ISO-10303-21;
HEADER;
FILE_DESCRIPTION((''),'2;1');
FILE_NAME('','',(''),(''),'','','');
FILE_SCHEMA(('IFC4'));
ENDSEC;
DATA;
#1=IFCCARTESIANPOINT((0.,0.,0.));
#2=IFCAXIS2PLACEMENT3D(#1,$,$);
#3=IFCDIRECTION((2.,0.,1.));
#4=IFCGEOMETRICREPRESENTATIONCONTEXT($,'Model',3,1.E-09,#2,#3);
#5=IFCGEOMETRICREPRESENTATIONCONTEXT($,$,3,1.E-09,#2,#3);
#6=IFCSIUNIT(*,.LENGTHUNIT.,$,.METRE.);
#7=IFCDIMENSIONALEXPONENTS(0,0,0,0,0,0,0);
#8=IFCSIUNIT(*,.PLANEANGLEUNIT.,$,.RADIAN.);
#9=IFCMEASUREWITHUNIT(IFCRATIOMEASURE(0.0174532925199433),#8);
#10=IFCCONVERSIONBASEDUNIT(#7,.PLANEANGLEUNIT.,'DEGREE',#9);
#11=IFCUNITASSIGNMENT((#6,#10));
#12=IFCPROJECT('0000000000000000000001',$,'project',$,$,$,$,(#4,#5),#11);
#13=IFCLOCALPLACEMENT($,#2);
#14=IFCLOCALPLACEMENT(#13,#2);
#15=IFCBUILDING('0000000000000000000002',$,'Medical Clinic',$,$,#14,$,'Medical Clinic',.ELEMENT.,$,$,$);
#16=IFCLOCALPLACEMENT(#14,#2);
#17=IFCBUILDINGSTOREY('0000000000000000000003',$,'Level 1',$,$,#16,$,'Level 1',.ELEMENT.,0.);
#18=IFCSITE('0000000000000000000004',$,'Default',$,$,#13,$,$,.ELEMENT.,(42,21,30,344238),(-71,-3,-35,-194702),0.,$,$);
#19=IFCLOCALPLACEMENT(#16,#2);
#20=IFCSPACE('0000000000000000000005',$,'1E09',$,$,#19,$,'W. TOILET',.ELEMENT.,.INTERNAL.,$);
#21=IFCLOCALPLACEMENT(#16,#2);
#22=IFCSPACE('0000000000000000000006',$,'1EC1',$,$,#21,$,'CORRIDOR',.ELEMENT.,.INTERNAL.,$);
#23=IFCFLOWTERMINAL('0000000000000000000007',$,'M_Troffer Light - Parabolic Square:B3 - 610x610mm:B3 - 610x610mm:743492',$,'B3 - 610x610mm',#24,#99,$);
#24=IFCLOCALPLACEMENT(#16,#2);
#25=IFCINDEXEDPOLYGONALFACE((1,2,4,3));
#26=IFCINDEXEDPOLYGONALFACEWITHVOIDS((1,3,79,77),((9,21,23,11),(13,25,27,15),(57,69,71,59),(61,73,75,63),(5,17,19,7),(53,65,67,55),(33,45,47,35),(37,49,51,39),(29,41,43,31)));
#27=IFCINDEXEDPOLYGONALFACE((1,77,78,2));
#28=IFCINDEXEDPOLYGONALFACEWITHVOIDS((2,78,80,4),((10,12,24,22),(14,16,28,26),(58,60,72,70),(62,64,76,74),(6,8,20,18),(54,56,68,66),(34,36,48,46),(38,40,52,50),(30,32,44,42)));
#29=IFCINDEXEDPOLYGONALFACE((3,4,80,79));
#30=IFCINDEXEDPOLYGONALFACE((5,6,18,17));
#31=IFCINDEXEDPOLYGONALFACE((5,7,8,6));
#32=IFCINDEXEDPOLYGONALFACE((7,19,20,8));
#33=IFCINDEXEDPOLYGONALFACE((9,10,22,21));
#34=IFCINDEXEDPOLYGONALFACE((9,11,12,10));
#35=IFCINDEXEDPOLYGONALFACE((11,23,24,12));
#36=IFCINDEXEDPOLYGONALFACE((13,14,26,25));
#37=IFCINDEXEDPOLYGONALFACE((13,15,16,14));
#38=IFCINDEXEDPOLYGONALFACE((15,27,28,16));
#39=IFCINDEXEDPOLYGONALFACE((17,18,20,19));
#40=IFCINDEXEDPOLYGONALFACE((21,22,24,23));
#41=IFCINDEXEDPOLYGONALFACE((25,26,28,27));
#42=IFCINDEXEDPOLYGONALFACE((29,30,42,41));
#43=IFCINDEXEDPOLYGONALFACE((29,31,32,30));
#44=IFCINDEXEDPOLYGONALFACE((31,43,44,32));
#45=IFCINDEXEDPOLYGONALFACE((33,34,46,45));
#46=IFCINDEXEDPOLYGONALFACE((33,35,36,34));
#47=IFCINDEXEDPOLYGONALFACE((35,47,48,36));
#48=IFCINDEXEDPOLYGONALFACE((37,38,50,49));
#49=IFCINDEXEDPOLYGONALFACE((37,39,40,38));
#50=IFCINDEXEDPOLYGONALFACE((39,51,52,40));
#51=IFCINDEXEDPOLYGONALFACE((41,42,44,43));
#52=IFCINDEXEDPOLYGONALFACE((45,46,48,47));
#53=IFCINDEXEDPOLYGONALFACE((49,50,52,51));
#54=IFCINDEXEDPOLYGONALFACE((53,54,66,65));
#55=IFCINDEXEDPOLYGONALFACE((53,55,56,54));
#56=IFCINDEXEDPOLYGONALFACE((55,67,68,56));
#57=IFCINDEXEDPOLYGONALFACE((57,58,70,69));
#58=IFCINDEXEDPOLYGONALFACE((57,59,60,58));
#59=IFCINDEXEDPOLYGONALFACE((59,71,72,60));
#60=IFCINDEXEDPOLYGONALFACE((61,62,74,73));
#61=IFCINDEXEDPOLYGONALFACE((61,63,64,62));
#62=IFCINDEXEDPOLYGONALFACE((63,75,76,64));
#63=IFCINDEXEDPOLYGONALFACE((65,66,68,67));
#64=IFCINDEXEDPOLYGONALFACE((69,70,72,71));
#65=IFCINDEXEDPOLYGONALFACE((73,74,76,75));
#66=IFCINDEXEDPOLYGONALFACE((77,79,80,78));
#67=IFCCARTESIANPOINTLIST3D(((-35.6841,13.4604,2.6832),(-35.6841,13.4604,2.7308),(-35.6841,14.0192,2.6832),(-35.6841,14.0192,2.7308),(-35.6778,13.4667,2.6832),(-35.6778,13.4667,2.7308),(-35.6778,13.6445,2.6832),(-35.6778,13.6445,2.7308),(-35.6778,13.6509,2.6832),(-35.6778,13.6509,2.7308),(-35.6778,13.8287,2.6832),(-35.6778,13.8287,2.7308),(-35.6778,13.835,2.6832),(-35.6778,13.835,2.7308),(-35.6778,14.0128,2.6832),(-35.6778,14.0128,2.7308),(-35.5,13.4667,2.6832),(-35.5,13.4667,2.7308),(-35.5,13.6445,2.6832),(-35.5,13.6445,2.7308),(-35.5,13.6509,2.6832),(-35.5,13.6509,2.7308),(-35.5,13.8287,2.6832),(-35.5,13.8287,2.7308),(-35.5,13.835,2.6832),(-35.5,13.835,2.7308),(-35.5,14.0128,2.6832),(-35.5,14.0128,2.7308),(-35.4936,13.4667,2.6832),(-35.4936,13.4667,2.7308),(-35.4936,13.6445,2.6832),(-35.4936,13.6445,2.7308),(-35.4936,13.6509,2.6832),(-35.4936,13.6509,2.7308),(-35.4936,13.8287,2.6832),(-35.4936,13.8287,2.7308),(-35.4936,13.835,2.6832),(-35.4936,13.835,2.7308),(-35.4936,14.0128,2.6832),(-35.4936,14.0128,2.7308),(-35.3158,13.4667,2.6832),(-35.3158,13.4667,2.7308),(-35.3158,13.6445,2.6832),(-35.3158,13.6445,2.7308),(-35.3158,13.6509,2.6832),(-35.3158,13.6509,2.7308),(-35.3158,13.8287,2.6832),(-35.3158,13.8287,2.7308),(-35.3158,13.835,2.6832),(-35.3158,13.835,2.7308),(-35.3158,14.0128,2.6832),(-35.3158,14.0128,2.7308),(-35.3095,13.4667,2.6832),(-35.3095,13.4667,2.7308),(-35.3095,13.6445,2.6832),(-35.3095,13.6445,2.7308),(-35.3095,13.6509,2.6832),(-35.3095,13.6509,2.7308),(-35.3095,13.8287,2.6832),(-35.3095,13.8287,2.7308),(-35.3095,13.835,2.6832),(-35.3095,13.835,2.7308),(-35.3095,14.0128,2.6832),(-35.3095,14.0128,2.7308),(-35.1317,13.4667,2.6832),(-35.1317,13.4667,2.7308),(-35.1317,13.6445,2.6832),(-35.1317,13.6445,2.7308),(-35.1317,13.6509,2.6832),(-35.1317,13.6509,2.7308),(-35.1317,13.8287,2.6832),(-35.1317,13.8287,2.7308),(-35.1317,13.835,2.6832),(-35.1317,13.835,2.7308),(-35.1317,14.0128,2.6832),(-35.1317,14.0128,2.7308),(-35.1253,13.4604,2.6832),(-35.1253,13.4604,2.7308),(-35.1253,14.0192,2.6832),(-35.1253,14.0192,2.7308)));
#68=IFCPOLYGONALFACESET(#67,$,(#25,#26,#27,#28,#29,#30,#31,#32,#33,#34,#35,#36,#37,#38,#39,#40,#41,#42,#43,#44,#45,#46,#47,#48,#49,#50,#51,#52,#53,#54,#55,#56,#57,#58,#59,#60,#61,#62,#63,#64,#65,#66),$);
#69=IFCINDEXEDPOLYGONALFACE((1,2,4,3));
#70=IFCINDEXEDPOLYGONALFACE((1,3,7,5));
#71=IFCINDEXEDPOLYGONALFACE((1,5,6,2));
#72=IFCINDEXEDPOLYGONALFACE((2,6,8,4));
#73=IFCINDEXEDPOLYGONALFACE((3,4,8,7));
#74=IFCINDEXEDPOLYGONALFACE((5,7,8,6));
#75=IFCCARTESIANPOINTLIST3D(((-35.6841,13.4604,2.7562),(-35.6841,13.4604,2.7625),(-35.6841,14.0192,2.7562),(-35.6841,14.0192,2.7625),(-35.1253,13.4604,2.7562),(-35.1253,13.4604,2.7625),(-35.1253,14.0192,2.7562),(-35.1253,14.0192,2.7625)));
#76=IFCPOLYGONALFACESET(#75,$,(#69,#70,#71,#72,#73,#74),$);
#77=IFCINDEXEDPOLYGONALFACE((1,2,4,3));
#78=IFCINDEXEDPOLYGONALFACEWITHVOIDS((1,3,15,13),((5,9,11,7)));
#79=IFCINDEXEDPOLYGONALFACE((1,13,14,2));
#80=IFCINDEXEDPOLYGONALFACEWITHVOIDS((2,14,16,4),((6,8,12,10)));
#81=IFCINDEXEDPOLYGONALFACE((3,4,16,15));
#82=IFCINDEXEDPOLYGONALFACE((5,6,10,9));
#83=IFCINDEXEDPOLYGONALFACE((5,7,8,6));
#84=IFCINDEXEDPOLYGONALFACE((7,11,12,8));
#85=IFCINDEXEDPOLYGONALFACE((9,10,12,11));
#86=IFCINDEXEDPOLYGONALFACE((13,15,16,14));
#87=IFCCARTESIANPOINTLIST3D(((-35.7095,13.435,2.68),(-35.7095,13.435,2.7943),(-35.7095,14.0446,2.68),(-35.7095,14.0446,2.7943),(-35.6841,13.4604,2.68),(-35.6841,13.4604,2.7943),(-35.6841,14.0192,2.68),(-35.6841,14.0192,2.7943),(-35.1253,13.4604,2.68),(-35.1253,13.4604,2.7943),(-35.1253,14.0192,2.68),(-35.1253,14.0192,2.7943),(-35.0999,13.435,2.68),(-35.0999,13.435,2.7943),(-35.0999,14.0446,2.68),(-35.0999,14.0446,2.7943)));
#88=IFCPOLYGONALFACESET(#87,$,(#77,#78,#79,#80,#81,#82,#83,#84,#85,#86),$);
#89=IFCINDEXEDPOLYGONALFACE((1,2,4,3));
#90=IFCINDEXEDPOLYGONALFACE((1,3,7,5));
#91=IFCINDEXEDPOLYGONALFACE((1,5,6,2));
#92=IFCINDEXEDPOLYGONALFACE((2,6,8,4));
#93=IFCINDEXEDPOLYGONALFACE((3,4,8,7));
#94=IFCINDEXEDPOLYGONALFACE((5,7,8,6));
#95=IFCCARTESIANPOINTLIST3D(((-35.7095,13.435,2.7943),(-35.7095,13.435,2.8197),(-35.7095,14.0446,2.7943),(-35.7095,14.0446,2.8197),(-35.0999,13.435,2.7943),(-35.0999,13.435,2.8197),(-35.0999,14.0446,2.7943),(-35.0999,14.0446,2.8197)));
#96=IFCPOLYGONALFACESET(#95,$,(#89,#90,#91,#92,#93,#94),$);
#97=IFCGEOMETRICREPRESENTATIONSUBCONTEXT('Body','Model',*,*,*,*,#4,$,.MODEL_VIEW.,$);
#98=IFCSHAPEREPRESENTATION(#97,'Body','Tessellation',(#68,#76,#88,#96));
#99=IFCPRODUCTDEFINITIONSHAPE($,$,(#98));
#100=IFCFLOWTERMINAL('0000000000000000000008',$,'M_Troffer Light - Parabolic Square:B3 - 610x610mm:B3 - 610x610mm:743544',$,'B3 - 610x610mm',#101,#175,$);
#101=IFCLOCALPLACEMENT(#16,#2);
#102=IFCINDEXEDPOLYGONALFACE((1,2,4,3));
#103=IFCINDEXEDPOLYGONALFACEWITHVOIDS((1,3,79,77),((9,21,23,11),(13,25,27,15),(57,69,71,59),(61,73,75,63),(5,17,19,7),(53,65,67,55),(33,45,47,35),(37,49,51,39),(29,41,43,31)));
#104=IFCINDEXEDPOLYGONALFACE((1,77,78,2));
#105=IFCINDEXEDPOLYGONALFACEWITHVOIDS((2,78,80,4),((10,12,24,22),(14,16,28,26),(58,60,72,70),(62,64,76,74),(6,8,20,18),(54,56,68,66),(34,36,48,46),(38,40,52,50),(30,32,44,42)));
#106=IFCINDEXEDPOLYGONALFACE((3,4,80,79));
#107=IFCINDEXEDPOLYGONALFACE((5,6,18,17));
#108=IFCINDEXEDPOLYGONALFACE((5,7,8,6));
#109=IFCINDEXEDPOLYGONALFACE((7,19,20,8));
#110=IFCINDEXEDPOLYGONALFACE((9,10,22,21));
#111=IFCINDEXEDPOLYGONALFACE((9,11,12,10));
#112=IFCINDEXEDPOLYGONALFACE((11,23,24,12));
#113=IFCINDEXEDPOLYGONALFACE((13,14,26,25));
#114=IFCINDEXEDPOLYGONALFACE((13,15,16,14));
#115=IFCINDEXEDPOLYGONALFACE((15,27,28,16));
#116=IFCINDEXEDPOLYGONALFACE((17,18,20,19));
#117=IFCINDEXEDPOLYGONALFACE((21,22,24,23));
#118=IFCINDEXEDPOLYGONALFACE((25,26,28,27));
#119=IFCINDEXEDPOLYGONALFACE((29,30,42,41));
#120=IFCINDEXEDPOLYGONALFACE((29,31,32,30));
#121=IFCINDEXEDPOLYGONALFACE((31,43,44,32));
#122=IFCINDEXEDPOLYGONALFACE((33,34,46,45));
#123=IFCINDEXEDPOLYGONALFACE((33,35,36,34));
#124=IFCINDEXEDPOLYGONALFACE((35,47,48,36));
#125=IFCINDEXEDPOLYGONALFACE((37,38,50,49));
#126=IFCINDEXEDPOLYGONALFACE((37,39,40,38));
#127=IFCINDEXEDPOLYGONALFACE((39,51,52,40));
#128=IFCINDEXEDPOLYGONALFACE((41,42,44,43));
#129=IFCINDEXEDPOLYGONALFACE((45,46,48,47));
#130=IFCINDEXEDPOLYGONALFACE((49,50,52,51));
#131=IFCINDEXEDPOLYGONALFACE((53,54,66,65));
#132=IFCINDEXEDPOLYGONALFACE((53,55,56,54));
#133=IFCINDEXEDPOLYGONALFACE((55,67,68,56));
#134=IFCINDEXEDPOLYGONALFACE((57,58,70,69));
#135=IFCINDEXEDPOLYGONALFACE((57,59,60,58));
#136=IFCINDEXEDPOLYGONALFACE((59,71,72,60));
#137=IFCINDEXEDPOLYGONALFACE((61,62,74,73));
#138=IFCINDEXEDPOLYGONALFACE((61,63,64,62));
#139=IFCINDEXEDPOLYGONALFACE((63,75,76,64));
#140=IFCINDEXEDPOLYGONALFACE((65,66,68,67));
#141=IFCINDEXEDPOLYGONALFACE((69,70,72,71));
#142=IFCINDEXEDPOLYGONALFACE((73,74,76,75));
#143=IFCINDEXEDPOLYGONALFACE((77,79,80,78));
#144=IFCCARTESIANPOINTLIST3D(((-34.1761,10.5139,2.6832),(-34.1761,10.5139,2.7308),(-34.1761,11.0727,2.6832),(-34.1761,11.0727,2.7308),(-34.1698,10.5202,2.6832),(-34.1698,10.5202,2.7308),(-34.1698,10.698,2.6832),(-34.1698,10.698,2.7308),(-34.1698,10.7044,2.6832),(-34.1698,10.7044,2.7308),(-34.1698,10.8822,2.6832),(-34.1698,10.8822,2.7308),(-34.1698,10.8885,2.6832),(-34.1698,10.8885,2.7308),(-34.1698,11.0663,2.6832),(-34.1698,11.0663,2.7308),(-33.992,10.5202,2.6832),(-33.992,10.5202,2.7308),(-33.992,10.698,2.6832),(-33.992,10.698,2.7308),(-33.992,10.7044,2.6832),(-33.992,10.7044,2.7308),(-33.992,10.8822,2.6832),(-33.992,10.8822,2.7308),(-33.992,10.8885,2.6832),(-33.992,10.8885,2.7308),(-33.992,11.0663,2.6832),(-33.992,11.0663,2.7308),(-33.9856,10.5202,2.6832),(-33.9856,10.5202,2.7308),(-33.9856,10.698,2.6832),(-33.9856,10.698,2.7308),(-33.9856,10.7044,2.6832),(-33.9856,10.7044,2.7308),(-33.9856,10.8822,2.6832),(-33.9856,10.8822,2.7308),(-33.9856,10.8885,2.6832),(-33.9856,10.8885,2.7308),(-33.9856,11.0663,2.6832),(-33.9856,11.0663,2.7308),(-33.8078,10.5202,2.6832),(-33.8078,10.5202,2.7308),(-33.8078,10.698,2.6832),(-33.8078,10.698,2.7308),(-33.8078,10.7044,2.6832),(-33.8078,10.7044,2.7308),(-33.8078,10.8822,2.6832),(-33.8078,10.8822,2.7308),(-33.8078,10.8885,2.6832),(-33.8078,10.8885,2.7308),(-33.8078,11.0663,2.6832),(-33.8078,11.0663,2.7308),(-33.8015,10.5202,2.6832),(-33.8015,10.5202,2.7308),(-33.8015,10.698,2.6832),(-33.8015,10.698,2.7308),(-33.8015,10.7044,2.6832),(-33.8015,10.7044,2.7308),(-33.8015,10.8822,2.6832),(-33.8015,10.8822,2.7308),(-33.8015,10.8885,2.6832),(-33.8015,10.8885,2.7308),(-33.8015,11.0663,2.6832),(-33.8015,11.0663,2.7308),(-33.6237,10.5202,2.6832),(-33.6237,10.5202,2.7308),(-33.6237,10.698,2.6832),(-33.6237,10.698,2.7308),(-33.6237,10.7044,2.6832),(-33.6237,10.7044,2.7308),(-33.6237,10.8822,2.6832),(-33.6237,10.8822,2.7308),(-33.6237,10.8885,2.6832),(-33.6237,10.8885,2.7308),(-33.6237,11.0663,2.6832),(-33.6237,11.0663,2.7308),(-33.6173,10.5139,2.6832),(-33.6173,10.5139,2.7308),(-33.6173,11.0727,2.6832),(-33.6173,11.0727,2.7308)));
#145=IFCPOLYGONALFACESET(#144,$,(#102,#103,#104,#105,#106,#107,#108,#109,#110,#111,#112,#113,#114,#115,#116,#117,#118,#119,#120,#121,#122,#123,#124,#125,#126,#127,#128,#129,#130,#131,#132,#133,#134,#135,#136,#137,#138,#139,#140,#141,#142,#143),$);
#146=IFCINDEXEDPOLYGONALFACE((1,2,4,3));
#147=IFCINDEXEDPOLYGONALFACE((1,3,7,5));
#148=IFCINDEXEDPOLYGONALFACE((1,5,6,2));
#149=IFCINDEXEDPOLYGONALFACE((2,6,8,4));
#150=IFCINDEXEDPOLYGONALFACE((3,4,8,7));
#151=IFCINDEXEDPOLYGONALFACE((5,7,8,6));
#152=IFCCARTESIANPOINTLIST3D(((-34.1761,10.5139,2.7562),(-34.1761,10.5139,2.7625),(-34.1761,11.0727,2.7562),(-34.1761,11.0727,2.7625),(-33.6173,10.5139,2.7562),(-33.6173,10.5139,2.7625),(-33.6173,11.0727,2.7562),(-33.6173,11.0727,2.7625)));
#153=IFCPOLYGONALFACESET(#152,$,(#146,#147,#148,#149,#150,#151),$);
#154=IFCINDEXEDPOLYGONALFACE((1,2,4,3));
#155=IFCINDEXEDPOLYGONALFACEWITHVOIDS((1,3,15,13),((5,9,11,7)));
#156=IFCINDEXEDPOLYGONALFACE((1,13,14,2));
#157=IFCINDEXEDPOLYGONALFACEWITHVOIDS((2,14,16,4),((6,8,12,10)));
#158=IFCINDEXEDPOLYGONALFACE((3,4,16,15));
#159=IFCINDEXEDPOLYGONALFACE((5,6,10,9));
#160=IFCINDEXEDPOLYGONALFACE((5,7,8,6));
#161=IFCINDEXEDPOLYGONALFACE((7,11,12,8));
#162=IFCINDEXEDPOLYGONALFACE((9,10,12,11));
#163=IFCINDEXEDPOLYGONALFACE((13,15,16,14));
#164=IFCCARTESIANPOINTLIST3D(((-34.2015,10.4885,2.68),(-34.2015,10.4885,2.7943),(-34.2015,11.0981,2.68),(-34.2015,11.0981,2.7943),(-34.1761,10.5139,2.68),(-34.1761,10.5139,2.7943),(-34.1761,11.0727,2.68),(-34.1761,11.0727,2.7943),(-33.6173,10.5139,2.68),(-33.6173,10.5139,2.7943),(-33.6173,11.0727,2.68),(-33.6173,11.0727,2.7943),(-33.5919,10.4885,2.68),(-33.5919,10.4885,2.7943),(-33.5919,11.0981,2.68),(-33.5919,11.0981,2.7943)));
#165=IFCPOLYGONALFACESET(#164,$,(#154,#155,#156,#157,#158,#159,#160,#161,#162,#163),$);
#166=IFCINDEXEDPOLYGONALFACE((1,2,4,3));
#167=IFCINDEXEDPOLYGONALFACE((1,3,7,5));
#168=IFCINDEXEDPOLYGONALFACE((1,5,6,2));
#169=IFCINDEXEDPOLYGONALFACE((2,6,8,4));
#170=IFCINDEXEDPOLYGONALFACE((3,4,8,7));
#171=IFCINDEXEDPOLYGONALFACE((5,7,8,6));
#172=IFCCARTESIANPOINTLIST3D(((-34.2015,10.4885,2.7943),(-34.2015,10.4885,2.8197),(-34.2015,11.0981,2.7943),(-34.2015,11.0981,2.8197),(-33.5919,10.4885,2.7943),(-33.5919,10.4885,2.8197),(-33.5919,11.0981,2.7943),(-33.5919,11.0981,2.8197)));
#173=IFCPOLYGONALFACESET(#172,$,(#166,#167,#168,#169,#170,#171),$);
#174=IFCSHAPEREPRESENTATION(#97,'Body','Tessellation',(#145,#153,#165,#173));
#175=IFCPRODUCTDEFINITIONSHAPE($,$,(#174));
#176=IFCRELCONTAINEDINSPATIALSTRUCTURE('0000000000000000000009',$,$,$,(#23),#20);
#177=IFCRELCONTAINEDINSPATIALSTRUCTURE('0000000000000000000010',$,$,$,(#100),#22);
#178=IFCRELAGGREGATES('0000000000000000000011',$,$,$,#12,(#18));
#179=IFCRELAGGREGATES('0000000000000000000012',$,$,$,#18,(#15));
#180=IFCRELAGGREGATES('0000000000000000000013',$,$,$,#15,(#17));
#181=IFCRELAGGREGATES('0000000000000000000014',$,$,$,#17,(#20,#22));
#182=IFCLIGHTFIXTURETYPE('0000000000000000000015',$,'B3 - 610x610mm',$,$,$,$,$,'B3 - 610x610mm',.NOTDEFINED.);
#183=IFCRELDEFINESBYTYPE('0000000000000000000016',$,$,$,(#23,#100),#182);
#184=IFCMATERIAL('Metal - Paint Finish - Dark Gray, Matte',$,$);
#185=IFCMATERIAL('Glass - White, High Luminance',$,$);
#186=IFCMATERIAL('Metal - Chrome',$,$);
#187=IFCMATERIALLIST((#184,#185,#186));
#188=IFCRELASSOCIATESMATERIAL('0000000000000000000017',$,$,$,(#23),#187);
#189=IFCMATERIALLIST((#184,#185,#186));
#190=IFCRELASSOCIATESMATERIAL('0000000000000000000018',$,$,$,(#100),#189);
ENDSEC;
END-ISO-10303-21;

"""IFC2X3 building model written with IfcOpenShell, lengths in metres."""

from ifc_helpers import new_model, entity, si_unit, converted_unit, direction, frame, origin, origin_2d_with_axis, place, context, subcontext, project, spatial, polyline, rectangle, outline, extrude, source, transform, mapped, material, material_list, type_object, type_shapes, element, save


model = new_model("IFC2X3")

# Units and contexts
model_context = context("Model", 3, precision=1e-09, world=origin(), true_north=direction((2.0, 0.0, 1.0)))
context_of_model = context(None, 3, precision=1e-09, world=origin(), true_north=direction((2.0, 0.0, 1.0)))
body_context = subcontext(model_context, "Body", "Model", "MODEL_VIEW")
ifc_project = project(units=[si_unit("LENGTHUNIT", "METRE"), converted_unit("PLANEANGLEUNIT", "DEGREE", entity("IfcRatioMeasure", 0.0174532925199433), si_unit("PLANEANGLEUNIT", "RADIAN"), dimensions=[0, 0, 0, 0, 0, 0, 0])], contexts=[model_context, context_of_model])

# Site, building, storey, space
site_placement = place(None, origin())
site = spatial("IfcSite", under=ifc_project, at=site_placement, Name="Default", CompositionType="ELEMENT", RefLatitude=(42, 21, 30, 344238), RefLongitude=(-71, -3, -35, -194702), RefElevation=0.0)
building_placement = place(site_placement, origin())
building = spatial("IfcBuilding", under=site, at=building_placement, Name="Medical Clinic", LongName="Medical Clinic", CompositionType="ELEMENT")
storey_placement = place(building_placement, origin())
storey = spatial("IfcBuildingStorey", under=building, at=storey_placement, Name="Level 1", LongName="Level 1", CompositionType="ELEMENT", Elevation=0.0)
space_1_placement = place(storey_placement, origin())
space_1 = spatial("IfcSpace", under=storey, at=space_1_placement, Name="1E09", LongName="W. TOILET", CompositionType="ELEMENT", InteriorOrExteriorSpace="INTERNAL")

# Flow terminal
ifc_material_1 = material(Name="Metal - Paint Finish - Dark Gray, Matte")
ifc_material_2 = material(Name="Glass - White, High Luminance")
ifc_material_3 = material(Name="Metal - Chrome")
ifc_material_list_1 = material_list([ifc_material_1, ifc_material_2, ifc_material_3])
light_fixture_type_1 = type_object("IfcLightFixtureType", Name="B3 - 610x610mm", ElementType="B3 - 610x610mm", PredefinedType="NOTDEFINED")
shared_shape_1 = source(origin(), body_context, "Body", "SweptSolid", [
    extrude(outline(polyline([(-0.2794, -0.2794), (0.2794, -0.2794), (0.2794, 0.2794), (-0.2794, 0.2794), (-0.2794, -0.2794)]), holes=[polyline([(-0.0952, 0.0953), (-0.273, 0.0953), (-0.273, 0.2731), (-0.0952, 0.2731), (-0.0952, 0.0953)]), polyline([(0.2731, 0.0953), (0.0953, 0.0953), (0.0953, 0.2731), (0.2731, 0.2731), (0.2731, 0.0953)]), polyline([(-0.0889, 0.2731), (0.0889, 0.2731), (0.0889, 0.0953), (-0.0889, 0.0953), (-0.0889, 0.2731)]), polyline([(0.2731, -0.273), (0.0953, -0.273), (0.0953, -0.0952), (0.2731, -0.0952), (0.2731, -0.273)]), polyline([(0.0889, -0.273), (-0.0889, -0.273), (-0.0889, -0.0952), (0.0889, -0.0952), (0.0889, -0.273)]), polyline([(-0.0952, -0.273), (-0.273, -0.273), (-0.273, -0.0952), (-0.0952, -0.0952), (-0.0952, -0.273)]), polyline([(-0.0952, -0.0889), (-0.273, -0.0889), (-0.273, 0.0889), (-0.0952, 0.0889), (-0.0952, -0.0889)]), polyline([(0.0889, -0.0889), (-0.0889, -0.0889), (-0.0889, 0.0889), (0.0889, 0.0889), (0.0889, -0.0889)]), polyline([(0.2731, -0.0889), (0.0953, -0.0889), (0.0953, 0.0889), (0.2731, 0.0889), (0.2731, -0.0889)])]), frame((0.0, -0.3048, -0.0508), z_axis=(0.0, 0.0, 1.0), x_axis=(-1.0, 0.0, 0.0)), (0.0, 0.0, 1.0), 0.0476),
    extrude(rectangle(XDim=0.5588, YDim=0.5588, at=origin_2d_with_axis()), frame((0.0, -0.3048, -0.0825), z_axis=(0.0, 0.0, 1.0), x_axis=(-1.0, 0.0, 0.0)), (0.0, 0.0, 1.0), 0.0064),
    extrude(outline(polyline([(-0.3048, -0.3048), (0.3048, -0.3048), (0.3048, 0.3048), (-0.3048, 0.3048), (-0.3048, -0.3048)]), holes=[polyline([(0.2794, 0.2794), (0.2794, -0.2794), (-0.2794, -0.2794), (-0.2794, 0.2794), (0.2794, 0.2794)])]), frame((0.0, -0.3048, -0.1143)), (0.0, 0.0, 1.0), 0.1143),
    extrude(rectangle(XDim=0.6096, YDim=0.6096, at=origin_2d_with_axis()), frame((0.0, -0.3048, -0.1397), z_axis=(0.0, 0.0, 1.0), x_axis=(-1.0, 0.0, 0.0)), (0.0, 0.0, 1.0), 0.0254),
])
type_shapes(light_fixture_type_1, [shared_shape_1])
flow_terminal_1_placement = place(space_1_placement, frame((-35.4047, 13.435, 2.68), z_axis=(0.0, 0.0, -1.0), x_axis=(1.0, 0.0, 0.0)))
element("IfcFlowTerminal", 1, at=flow_terminal_1_placement, inside=space_1, type_object=light_fixture_type_1, material=ifc_material_list_1, Name="M_Troffer Light - Parabolic Square:B3 - 610x610mm:B3 - 610x610mm:743492", ObjectType="B3 - 610x610mm", context=body_context, shape_type="MappedRepresentation", body=[
    mapped(shared_shape_1, transform((0.0, 0.0, 0.0), scale=1.0)),
])

# Shared definitions
space_2_placement = place(storey_placement, origin())
space_2 = spatial("IfcSpace", under=storey, at=space_2_placement, Name="1EC1", LongName="CORRIDOR", CompositionType="ELEMENT", InteriorOrExteriorSpace="INTERNAL")

# Flow terminal
ifc_material_list_2 = material_list([ifc_material_1, ifc_material_2, ifc_material_3])
flow_terminal_2_placement = place(space_2_placement, frame((-33.8967, 10.4885, 2.68), z_axis=(0.0, 0.0, -1.0), x_axis=(1.0, 0.0, 0.0)))
element("IfcFlowTerminal", 2, at=flow_terminal_2_placement, inside=space_2, type_object=light_fixture_type_1, material=ifc_material_list_2, Name="M_Troffer Light - Parabolic Square:B3 - 610x610mm:B3 - 610x610mm:743544", ObjectType="B3 - 610x610mm", context=body_context, shape_type="MappedRepresentation", body=[
    mapped(shared_shape_1, transform((0.0, 0.0, 0.0), scale=1.0)),
])

save(model, "model.ifc")
